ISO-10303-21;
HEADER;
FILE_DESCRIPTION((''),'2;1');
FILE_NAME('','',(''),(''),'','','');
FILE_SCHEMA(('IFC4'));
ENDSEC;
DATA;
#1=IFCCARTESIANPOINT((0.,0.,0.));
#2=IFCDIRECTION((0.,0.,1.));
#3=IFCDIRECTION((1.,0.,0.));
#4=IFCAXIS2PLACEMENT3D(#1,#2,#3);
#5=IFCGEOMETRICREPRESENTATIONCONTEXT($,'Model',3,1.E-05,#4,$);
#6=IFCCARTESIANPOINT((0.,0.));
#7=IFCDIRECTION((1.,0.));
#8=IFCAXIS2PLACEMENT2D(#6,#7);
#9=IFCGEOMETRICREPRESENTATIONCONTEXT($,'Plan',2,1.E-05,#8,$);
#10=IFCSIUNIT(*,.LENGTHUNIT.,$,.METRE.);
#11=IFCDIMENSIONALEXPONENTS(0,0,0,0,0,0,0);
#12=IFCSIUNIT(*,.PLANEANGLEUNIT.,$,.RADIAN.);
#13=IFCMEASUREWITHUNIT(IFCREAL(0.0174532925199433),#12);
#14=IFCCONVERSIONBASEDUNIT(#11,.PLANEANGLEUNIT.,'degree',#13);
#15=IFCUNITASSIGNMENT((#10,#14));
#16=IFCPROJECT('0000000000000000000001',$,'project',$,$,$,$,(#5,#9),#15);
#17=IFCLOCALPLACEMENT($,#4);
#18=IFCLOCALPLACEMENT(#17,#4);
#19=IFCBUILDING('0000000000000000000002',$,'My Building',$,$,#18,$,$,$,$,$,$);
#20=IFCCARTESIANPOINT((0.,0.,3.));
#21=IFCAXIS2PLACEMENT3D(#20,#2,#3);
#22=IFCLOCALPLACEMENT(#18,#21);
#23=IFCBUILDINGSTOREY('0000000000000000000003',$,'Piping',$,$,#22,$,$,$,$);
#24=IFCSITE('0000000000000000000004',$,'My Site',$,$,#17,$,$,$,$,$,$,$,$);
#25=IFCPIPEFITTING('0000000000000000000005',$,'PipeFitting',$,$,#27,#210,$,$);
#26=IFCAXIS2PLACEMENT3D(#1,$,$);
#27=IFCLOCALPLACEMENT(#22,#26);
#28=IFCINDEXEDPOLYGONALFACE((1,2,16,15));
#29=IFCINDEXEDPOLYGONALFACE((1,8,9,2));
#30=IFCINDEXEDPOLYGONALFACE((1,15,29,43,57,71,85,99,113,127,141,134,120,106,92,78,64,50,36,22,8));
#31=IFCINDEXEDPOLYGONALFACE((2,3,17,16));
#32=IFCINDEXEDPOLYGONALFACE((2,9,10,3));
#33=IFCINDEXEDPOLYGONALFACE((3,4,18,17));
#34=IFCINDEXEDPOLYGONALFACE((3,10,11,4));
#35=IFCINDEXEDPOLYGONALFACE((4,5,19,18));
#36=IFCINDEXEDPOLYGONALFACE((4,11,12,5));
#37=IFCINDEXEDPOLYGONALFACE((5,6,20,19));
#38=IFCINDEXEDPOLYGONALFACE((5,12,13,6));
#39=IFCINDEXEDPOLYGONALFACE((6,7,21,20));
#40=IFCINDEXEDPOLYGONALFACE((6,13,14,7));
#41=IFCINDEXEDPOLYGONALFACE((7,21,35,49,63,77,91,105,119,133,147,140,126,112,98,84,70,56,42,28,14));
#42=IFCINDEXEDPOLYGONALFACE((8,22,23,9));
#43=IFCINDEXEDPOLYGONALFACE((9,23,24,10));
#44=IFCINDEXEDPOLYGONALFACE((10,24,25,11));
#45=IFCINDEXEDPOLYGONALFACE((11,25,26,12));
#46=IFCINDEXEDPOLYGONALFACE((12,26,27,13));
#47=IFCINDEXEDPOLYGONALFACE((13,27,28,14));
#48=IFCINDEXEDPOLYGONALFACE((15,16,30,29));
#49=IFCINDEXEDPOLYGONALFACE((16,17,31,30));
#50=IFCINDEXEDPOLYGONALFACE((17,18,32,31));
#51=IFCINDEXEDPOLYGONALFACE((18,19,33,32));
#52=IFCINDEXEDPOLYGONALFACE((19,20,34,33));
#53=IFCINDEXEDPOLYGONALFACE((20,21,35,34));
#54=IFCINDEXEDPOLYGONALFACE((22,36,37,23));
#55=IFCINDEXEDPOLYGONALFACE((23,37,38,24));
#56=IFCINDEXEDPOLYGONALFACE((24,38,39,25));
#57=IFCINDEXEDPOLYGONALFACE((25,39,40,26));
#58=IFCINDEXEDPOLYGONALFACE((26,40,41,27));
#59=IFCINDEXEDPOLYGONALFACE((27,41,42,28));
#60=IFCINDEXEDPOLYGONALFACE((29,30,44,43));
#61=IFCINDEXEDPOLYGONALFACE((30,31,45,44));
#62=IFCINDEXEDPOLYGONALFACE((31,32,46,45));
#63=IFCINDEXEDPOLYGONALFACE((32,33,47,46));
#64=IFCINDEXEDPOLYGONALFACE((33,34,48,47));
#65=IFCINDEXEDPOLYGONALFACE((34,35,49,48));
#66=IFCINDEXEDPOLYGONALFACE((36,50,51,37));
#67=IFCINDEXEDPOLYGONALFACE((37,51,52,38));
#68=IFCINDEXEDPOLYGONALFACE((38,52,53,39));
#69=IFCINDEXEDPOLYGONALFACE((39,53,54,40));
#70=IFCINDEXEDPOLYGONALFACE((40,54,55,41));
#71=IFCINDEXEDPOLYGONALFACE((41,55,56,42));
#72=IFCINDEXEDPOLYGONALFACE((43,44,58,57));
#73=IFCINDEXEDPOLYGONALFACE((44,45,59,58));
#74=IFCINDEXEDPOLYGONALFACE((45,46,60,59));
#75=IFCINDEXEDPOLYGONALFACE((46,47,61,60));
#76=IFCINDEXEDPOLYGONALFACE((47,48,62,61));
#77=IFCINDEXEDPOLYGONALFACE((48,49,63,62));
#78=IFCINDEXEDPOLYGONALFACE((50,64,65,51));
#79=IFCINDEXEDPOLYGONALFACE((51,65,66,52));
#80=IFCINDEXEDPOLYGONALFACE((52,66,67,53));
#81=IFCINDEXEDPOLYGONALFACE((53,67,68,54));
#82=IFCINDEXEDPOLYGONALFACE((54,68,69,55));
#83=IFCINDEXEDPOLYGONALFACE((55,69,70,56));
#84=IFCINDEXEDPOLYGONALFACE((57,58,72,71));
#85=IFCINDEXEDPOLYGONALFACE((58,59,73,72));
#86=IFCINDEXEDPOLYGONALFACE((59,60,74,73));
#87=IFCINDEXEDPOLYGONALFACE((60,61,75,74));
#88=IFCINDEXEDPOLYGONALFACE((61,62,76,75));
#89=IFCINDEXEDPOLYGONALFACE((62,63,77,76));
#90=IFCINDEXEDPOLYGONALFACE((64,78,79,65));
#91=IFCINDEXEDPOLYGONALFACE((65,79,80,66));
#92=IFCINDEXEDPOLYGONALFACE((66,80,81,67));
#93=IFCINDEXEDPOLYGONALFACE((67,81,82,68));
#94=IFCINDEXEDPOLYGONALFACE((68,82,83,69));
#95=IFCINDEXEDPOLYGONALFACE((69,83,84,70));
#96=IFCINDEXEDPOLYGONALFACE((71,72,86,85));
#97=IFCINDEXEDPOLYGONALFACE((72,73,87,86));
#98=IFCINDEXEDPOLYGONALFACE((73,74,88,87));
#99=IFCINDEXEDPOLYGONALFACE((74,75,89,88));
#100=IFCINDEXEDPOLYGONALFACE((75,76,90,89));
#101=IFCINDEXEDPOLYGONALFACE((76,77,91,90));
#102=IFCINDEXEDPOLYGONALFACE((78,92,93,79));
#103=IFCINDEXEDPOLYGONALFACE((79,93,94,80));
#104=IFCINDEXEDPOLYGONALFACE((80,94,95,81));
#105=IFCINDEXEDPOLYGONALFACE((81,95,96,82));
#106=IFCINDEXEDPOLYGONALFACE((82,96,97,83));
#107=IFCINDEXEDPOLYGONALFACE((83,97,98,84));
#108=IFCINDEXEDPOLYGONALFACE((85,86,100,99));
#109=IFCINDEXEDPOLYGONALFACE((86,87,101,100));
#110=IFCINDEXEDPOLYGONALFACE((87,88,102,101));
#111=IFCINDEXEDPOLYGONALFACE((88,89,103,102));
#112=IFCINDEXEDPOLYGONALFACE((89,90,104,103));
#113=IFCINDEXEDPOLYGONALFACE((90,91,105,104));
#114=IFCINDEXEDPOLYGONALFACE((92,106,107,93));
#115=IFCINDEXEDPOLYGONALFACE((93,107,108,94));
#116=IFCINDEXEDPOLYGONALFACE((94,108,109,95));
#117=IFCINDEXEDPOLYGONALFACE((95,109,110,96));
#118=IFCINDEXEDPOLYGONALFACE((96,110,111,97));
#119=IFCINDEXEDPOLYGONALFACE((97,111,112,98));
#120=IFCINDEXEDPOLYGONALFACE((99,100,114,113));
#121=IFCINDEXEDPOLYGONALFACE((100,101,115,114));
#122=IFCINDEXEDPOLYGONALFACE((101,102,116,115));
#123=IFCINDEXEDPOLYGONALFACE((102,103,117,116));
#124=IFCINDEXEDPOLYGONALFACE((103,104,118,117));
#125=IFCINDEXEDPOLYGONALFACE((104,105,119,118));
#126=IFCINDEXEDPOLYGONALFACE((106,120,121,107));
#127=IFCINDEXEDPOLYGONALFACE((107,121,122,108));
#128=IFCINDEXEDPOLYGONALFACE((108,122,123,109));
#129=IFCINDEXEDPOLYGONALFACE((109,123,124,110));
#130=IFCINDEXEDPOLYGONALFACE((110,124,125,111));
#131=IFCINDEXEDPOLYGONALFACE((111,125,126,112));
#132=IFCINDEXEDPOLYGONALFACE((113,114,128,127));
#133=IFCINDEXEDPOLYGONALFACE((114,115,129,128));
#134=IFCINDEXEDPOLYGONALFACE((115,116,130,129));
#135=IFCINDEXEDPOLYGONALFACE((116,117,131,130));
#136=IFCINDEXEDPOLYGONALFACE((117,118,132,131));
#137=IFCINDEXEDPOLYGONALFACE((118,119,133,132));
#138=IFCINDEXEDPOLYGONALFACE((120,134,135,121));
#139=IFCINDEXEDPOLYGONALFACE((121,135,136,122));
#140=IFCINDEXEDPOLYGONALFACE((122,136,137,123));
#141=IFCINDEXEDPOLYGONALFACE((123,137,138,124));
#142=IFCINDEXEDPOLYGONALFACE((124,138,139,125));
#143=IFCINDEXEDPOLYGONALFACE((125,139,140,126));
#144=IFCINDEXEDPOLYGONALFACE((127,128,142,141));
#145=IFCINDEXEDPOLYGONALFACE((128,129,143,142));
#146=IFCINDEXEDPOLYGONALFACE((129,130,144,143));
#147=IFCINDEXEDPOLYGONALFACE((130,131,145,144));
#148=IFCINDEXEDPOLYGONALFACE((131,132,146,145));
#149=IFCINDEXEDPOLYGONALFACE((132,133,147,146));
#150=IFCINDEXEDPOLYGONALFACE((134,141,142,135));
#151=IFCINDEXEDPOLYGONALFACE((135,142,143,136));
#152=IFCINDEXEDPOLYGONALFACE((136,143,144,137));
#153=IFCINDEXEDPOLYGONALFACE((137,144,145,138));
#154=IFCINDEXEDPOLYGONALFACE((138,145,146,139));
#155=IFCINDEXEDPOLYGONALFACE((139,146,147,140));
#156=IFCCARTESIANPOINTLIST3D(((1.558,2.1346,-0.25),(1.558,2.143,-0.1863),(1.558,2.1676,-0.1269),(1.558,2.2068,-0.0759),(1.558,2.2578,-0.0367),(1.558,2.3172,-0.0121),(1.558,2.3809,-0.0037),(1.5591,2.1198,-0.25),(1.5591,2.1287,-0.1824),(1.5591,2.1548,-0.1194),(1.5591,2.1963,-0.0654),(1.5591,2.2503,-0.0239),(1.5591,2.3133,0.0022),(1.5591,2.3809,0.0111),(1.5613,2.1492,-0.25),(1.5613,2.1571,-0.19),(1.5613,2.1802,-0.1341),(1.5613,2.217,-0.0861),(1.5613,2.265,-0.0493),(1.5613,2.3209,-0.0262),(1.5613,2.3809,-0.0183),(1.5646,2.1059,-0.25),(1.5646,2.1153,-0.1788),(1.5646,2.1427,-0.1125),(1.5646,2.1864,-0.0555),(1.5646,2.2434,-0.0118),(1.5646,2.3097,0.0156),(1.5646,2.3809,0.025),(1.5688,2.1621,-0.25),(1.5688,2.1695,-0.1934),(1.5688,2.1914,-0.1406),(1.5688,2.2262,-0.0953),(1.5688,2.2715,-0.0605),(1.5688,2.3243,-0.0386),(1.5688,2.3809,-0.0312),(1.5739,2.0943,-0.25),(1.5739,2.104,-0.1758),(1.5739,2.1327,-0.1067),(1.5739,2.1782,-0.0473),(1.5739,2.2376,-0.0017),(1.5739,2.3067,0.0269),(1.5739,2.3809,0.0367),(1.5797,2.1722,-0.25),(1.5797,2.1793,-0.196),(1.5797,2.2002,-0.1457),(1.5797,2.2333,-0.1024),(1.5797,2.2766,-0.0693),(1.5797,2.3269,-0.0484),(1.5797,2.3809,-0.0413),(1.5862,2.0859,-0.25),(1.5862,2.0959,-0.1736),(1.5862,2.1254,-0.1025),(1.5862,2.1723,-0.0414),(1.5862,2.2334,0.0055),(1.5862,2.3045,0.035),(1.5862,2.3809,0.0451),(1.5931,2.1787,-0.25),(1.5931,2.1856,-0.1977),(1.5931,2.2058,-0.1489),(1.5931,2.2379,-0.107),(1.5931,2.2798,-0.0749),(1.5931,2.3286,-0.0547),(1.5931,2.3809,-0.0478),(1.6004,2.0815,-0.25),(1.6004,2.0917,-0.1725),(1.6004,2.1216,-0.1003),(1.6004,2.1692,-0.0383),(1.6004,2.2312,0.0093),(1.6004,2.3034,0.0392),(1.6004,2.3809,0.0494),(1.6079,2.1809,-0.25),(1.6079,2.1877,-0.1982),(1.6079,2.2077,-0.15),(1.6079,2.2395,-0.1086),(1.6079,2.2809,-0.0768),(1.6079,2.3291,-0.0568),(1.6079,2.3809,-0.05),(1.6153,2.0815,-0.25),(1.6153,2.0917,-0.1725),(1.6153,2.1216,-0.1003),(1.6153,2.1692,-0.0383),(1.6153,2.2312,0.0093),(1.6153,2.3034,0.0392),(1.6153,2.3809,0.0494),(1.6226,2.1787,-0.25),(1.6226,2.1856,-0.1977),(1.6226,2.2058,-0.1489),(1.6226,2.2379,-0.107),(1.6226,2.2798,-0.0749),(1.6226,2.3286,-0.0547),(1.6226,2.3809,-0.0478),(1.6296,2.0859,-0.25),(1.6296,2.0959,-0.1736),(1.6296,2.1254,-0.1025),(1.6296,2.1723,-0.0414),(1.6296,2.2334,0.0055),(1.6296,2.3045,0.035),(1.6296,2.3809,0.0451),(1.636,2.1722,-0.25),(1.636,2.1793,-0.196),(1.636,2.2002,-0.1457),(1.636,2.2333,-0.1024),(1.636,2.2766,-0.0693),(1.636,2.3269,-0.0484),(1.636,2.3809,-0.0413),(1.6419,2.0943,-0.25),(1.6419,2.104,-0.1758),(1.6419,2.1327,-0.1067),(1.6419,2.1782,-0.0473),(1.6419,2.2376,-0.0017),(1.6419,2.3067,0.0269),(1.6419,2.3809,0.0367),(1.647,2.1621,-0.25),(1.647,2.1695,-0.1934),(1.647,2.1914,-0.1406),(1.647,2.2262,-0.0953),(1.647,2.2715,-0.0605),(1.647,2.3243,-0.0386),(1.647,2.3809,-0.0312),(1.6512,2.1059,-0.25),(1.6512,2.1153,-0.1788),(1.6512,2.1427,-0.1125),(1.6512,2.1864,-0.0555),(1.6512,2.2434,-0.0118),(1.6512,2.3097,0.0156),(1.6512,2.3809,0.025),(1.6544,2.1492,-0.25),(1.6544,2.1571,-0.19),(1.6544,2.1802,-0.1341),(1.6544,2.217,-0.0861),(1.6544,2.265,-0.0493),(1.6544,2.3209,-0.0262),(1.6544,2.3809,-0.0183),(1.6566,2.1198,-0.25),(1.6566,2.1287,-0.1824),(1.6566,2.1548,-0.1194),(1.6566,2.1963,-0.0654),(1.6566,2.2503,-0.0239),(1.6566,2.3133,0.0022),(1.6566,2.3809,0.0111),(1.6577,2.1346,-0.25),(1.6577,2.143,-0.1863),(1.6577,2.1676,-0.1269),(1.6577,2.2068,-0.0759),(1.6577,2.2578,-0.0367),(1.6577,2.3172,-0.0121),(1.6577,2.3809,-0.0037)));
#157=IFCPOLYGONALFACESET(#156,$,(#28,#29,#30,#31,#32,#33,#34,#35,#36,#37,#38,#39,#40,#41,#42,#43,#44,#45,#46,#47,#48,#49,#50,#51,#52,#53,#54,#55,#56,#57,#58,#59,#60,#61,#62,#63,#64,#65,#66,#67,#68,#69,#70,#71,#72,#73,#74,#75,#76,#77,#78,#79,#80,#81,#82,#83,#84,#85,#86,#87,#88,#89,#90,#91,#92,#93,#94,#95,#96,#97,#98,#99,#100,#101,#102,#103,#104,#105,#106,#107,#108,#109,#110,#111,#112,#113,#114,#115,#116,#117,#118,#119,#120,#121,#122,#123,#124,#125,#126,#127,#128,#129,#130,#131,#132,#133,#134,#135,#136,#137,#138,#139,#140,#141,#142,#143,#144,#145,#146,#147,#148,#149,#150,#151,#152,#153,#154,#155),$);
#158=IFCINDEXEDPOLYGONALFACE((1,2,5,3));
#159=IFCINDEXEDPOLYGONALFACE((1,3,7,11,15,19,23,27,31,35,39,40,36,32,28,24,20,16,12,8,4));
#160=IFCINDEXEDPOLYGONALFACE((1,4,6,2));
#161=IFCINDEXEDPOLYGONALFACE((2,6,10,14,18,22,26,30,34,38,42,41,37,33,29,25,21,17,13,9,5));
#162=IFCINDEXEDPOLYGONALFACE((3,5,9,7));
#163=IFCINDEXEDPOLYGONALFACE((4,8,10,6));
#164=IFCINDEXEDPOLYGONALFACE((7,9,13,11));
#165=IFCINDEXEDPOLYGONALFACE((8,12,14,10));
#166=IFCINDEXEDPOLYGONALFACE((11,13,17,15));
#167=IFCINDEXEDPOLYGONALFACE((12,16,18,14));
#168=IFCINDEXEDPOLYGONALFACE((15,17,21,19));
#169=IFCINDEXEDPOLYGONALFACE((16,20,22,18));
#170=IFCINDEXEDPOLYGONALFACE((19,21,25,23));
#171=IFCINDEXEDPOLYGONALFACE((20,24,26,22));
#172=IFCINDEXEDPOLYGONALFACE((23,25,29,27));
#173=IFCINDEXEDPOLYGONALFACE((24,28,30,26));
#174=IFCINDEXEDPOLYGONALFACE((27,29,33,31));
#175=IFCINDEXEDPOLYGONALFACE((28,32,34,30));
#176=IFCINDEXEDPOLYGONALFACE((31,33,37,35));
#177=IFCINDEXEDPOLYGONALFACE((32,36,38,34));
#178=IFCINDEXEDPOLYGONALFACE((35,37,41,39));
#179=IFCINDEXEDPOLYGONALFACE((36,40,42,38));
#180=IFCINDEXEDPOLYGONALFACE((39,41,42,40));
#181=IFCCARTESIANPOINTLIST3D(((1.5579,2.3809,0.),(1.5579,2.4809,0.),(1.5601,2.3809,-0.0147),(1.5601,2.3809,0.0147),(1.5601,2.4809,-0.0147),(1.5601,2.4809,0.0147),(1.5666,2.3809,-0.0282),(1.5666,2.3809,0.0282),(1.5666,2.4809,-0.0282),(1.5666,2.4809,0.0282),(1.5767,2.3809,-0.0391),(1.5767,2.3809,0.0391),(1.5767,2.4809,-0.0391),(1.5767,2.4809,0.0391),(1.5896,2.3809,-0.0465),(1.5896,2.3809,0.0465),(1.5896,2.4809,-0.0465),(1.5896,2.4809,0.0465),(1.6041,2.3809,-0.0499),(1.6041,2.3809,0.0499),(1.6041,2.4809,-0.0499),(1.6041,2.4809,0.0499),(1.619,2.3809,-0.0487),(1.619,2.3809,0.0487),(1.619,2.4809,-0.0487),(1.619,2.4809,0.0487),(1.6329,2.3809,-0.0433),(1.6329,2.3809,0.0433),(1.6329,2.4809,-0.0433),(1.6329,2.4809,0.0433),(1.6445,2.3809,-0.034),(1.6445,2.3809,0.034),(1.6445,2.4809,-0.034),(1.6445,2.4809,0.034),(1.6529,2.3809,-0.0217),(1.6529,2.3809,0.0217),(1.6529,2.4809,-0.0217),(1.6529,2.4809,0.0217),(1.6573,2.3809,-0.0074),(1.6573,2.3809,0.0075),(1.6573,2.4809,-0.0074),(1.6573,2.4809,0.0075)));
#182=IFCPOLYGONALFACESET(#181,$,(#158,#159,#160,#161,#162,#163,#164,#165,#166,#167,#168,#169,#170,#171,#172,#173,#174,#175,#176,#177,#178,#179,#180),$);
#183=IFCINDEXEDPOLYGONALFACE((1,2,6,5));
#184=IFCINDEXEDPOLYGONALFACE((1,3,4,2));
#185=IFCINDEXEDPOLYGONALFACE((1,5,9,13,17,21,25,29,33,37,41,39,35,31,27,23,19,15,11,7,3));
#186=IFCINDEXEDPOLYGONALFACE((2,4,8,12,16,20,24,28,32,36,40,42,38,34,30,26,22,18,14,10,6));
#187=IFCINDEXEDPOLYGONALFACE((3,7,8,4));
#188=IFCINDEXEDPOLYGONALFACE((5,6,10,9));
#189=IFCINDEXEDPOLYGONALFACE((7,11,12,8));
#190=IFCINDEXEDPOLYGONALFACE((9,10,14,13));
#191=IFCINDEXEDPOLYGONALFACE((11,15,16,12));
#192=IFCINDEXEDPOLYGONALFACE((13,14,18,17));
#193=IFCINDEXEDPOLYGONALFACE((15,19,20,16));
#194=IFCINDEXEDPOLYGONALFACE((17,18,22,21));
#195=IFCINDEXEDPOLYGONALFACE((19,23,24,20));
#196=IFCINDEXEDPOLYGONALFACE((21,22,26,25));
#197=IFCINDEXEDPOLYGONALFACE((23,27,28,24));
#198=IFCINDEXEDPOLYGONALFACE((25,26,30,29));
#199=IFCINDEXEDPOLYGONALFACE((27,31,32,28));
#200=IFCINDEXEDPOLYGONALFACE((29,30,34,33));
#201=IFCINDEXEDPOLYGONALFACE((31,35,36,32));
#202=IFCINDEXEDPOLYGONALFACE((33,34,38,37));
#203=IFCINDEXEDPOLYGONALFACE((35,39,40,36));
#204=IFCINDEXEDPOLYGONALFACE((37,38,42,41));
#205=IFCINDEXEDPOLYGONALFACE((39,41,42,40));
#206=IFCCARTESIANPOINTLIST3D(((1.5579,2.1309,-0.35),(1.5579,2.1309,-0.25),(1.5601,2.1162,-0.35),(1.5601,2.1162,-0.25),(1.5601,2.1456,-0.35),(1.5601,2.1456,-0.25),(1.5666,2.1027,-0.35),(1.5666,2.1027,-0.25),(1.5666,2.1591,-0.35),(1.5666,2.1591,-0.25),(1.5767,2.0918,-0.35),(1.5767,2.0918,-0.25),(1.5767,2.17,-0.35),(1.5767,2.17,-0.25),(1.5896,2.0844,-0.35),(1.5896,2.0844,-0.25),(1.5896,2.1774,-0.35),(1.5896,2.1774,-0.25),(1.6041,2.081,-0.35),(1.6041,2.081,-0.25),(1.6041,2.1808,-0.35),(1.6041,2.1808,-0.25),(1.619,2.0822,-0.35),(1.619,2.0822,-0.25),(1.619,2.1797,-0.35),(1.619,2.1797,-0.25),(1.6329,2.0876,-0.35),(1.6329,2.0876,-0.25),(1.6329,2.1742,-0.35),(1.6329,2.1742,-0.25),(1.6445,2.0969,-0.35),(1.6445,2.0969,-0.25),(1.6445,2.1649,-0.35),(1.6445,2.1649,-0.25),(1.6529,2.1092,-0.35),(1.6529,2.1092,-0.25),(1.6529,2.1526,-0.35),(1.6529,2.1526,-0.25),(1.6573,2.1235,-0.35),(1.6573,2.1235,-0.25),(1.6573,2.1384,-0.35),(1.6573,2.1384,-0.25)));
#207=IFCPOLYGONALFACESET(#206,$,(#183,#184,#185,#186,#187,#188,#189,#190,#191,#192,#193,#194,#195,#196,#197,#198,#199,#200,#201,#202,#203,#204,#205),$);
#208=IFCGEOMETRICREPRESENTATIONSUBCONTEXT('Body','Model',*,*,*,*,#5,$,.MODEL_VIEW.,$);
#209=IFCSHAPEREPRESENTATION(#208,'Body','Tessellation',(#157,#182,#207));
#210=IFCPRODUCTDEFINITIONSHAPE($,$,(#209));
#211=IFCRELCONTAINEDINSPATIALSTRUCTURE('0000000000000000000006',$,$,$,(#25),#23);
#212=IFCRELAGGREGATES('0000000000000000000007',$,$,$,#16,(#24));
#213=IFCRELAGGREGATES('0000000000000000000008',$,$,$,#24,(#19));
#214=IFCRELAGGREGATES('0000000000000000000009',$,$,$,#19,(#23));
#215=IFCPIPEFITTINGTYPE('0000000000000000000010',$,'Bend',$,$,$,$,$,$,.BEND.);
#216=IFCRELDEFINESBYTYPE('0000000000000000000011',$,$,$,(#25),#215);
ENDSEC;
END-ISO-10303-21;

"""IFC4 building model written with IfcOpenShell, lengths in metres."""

from ifc_helpers import new_model, entity, si_unit, converted_unit, frame, origin_with_axes, origin_2d_with_axis, place, context, subcontext, project, spatial, circle, extrude, source, transform, mapped, type_object, type_shapes, element, save


model = new_model("IFC4")

# Units and contexts
model_context = context("Model", 3, precision=1e-05, world=origin_with_axes())
plan_context = context("Plan", 2, precision=1e-05, world=origin_2d_with_axis())
body_context = subcontext(model_context, "Body", "Model", "MODEL_VIEW")
ifc_project = project(units=[si_unit("LENGTHUNIT", "METRE"), converted_unit("PLANEANGLEUNIT", "degree", entity("IfcReal", 0.0174532925199433), si_unit("PLANEANGLEUNIT", "RADIAN"), dimensions=[0, 0, 0, 0, 0, 0, 0])], contexts=[model_context, plan_context])

# Site, building, storey
site_placement = place(None, origin_with_axes())
site = spatial("IfcSite", under=ifc_project, at=site_placement, Name="My Site")
building_placement = place(site_placement, origin_with_axes())
building = spatial("IfcBuilding", under=site, at=building_placement, Name="My Building")
storey_placement = place(building_placement, frame((0.0, 0.0, 3.0), z_axis=(0.0, 0.0, 1.0), x_axis=(1.0, 0.0, 0.0)))
storey = spatial("IfcBuildingStorey", under=building, at=storey_placement, Name="Piping")

# Pipe fitting
pipe_fitting_type = type_object("IfcPipeFittingType", Name="Bend", PredefinedType="BEND")
shared_shape = source(origin_with_axes(), body_context, "Body", "SolidModel", [
    entity("IfcSweptDiskSolid", entity("IfcIndexedPolyCurve", entity("IfcCartesianPointList3D", [[0.0, 0.0, -0.1], [0.0, -0.0732, -0.2768], [0.0, -0.25, -0.35]]), [entity("IfcArcIndex", [1, 2, 3])]), 0.05),
    extrude(circle(Radius=0.05), origin_with_axes(), (0.0, 0.0, -1.0), 0.1),
    extrude(circle(Radius=0.05), frame((0.0, -0.25, -0.35), z_axis=(0.0, -1.0, 0.0), x_axis=(1.0, 0.0, 0.0)), (0.0, 0.0, 1.0), 0.1),
])
type_shapes(pipe_fitting_type, [shared_shape])
for number, where, z_axis, x_axis, name in (
    (1, (1.6079, 2.4809, 0.0), (0.0, 1.0, 0.0), (-1.0, 0.0, 0.0), "PipeFitting"),
):
    element("IfcPipeFitting", number, at=place(storey_placement, frame(where, z_axis=z_axis, x_axis=x_axis)), inside=storey, type_object=pipe_fitting_type, Name=name, context=body_context, shape_type="MappedRepresentation", body=[
        mapped(shared_shape, transform((0.0, 0.0, 0.0), x_axis=(1.0, 0.0, 0.0), y_axis=(0.0, 1.0, 0.0), z_axis=(0.0, 0.0, 1.0), scale=1.0)),
    ])

save(model, "model.ifc")
